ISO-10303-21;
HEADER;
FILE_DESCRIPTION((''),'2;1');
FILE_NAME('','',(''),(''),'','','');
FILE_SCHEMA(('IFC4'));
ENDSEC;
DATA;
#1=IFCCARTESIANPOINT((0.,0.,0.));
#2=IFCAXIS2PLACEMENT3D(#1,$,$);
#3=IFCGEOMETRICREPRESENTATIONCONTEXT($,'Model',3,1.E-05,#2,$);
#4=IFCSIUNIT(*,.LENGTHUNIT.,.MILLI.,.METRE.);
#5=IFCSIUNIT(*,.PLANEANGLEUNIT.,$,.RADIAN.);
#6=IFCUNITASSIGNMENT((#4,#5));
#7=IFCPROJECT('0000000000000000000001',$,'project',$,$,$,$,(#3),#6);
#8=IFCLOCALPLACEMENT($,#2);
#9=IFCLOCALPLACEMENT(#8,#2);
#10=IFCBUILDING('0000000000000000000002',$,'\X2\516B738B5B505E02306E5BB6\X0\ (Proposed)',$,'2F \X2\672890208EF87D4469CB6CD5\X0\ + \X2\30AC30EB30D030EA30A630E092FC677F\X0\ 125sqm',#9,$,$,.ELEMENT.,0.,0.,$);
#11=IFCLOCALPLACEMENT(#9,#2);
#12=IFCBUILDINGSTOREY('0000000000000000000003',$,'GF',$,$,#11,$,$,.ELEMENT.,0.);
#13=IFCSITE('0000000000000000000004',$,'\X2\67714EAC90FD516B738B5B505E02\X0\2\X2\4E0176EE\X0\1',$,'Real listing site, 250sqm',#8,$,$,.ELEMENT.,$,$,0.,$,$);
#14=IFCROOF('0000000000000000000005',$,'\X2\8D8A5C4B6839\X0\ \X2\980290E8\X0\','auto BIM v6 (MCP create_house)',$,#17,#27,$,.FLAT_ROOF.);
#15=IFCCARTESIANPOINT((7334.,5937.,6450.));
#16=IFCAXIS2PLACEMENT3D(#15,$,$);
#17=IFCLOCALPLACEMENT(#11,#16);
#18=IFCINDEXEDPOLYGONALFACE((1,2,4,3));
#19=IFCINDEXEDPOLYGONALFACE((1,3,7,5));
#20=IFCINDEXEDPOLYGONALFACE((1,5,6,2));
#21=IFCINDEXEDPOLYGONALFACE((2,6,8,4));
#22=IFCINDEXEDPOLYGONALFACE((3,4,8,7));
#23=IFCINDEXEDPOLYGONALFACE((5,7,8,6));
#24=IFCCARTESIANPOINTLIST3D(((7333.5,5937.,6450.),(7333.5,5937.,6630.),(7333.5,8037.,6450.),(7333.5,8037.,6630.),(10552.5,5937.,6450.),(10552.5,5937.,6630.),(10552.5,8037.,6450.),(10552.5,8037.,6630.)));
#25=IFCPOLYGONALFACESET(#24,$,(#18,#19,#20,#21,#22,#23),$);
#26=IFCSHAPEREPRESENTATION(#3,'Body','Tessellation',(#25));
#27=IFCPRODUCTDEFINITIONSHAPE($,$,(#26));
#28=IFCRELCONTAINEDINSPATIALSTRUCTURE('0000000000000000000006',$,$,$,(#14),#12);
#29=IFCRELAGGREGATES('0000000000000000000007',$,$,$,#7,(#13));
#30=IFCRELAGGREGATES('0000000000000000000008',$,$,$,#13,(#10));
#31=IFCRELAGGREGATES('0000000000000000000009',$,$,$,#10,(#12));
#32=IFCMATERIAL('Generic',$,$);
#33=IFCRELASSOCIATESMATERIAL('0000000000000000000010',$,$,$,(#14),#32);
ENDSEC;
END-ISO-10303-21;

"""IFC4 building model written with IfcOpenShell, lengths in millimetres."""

from ifc_helpers import new_model, si_unit, frame, frame_2d, origin, place, context, project, spatial, rectangle, extrude, material, element, save


model = new_model("IFC4")

# Units and contexts
model_context = context("Model", 3, precision=1e-05, world=origin())
ifc_project = project(units=[si_unit("LENGTHUNIT", "METRE", prefix="MILLI"), si_unit("PLANEANGLEUNIT", "RADIAN")], contexts=[model_context])

# Site, building, storey
site_placement = place(None, origin())
site = spatial("IfcSite", under=ifc_project, at=site_placement, Name="東京都八王子市2丁目1", ObjectType="Real listing site, 250sqm", CompositionType="ELEMENT", RefElevation=0.0)
building_placement = place(site_placement, origin())
building = spatial("IfcBuilding", under=site, at=building_placement, Name="八王子市の家 (Proposed)", ObjectType="2F 木造軸組構法 + ガルバリウム鋼板 125sqm", CompositionType="ELEMENT", ElevationOfRefHeight=0.0, ElevationOfTerrain=0.0)
storey_placement = place(building_placement, origin())
storey = spatial("IfcBuildingStorey", under=building, at=storey_placement, Name="GF", CompositionType="ELEMENT", Elevation=0.0)

# Shared definitions
ifc_material = material(Name="Generic")

# Roof
roof_placement = place(storey_placement, frame((7334.0, 5937.0, 6450.0)))
element("IfcRoof", 1, at=roof_placement, inside=storey, material=ifc_material, Name="越屋根 頂部", Description="auto BIM v6 (MCP create_house)", PredefinedType="FLAT_ROOF", context=model_context, shape_type="SweptSolid", body=[
    extrude(rectangle(XDim=3219.0, YDim=2100.0, at=frame_2d((1609.0, 1050.0))), frame((7334.0, 5937.0, 6450.0)), (0.0, 0.0, 1.0), 180.0),
])

save(model, "model.ifc")
